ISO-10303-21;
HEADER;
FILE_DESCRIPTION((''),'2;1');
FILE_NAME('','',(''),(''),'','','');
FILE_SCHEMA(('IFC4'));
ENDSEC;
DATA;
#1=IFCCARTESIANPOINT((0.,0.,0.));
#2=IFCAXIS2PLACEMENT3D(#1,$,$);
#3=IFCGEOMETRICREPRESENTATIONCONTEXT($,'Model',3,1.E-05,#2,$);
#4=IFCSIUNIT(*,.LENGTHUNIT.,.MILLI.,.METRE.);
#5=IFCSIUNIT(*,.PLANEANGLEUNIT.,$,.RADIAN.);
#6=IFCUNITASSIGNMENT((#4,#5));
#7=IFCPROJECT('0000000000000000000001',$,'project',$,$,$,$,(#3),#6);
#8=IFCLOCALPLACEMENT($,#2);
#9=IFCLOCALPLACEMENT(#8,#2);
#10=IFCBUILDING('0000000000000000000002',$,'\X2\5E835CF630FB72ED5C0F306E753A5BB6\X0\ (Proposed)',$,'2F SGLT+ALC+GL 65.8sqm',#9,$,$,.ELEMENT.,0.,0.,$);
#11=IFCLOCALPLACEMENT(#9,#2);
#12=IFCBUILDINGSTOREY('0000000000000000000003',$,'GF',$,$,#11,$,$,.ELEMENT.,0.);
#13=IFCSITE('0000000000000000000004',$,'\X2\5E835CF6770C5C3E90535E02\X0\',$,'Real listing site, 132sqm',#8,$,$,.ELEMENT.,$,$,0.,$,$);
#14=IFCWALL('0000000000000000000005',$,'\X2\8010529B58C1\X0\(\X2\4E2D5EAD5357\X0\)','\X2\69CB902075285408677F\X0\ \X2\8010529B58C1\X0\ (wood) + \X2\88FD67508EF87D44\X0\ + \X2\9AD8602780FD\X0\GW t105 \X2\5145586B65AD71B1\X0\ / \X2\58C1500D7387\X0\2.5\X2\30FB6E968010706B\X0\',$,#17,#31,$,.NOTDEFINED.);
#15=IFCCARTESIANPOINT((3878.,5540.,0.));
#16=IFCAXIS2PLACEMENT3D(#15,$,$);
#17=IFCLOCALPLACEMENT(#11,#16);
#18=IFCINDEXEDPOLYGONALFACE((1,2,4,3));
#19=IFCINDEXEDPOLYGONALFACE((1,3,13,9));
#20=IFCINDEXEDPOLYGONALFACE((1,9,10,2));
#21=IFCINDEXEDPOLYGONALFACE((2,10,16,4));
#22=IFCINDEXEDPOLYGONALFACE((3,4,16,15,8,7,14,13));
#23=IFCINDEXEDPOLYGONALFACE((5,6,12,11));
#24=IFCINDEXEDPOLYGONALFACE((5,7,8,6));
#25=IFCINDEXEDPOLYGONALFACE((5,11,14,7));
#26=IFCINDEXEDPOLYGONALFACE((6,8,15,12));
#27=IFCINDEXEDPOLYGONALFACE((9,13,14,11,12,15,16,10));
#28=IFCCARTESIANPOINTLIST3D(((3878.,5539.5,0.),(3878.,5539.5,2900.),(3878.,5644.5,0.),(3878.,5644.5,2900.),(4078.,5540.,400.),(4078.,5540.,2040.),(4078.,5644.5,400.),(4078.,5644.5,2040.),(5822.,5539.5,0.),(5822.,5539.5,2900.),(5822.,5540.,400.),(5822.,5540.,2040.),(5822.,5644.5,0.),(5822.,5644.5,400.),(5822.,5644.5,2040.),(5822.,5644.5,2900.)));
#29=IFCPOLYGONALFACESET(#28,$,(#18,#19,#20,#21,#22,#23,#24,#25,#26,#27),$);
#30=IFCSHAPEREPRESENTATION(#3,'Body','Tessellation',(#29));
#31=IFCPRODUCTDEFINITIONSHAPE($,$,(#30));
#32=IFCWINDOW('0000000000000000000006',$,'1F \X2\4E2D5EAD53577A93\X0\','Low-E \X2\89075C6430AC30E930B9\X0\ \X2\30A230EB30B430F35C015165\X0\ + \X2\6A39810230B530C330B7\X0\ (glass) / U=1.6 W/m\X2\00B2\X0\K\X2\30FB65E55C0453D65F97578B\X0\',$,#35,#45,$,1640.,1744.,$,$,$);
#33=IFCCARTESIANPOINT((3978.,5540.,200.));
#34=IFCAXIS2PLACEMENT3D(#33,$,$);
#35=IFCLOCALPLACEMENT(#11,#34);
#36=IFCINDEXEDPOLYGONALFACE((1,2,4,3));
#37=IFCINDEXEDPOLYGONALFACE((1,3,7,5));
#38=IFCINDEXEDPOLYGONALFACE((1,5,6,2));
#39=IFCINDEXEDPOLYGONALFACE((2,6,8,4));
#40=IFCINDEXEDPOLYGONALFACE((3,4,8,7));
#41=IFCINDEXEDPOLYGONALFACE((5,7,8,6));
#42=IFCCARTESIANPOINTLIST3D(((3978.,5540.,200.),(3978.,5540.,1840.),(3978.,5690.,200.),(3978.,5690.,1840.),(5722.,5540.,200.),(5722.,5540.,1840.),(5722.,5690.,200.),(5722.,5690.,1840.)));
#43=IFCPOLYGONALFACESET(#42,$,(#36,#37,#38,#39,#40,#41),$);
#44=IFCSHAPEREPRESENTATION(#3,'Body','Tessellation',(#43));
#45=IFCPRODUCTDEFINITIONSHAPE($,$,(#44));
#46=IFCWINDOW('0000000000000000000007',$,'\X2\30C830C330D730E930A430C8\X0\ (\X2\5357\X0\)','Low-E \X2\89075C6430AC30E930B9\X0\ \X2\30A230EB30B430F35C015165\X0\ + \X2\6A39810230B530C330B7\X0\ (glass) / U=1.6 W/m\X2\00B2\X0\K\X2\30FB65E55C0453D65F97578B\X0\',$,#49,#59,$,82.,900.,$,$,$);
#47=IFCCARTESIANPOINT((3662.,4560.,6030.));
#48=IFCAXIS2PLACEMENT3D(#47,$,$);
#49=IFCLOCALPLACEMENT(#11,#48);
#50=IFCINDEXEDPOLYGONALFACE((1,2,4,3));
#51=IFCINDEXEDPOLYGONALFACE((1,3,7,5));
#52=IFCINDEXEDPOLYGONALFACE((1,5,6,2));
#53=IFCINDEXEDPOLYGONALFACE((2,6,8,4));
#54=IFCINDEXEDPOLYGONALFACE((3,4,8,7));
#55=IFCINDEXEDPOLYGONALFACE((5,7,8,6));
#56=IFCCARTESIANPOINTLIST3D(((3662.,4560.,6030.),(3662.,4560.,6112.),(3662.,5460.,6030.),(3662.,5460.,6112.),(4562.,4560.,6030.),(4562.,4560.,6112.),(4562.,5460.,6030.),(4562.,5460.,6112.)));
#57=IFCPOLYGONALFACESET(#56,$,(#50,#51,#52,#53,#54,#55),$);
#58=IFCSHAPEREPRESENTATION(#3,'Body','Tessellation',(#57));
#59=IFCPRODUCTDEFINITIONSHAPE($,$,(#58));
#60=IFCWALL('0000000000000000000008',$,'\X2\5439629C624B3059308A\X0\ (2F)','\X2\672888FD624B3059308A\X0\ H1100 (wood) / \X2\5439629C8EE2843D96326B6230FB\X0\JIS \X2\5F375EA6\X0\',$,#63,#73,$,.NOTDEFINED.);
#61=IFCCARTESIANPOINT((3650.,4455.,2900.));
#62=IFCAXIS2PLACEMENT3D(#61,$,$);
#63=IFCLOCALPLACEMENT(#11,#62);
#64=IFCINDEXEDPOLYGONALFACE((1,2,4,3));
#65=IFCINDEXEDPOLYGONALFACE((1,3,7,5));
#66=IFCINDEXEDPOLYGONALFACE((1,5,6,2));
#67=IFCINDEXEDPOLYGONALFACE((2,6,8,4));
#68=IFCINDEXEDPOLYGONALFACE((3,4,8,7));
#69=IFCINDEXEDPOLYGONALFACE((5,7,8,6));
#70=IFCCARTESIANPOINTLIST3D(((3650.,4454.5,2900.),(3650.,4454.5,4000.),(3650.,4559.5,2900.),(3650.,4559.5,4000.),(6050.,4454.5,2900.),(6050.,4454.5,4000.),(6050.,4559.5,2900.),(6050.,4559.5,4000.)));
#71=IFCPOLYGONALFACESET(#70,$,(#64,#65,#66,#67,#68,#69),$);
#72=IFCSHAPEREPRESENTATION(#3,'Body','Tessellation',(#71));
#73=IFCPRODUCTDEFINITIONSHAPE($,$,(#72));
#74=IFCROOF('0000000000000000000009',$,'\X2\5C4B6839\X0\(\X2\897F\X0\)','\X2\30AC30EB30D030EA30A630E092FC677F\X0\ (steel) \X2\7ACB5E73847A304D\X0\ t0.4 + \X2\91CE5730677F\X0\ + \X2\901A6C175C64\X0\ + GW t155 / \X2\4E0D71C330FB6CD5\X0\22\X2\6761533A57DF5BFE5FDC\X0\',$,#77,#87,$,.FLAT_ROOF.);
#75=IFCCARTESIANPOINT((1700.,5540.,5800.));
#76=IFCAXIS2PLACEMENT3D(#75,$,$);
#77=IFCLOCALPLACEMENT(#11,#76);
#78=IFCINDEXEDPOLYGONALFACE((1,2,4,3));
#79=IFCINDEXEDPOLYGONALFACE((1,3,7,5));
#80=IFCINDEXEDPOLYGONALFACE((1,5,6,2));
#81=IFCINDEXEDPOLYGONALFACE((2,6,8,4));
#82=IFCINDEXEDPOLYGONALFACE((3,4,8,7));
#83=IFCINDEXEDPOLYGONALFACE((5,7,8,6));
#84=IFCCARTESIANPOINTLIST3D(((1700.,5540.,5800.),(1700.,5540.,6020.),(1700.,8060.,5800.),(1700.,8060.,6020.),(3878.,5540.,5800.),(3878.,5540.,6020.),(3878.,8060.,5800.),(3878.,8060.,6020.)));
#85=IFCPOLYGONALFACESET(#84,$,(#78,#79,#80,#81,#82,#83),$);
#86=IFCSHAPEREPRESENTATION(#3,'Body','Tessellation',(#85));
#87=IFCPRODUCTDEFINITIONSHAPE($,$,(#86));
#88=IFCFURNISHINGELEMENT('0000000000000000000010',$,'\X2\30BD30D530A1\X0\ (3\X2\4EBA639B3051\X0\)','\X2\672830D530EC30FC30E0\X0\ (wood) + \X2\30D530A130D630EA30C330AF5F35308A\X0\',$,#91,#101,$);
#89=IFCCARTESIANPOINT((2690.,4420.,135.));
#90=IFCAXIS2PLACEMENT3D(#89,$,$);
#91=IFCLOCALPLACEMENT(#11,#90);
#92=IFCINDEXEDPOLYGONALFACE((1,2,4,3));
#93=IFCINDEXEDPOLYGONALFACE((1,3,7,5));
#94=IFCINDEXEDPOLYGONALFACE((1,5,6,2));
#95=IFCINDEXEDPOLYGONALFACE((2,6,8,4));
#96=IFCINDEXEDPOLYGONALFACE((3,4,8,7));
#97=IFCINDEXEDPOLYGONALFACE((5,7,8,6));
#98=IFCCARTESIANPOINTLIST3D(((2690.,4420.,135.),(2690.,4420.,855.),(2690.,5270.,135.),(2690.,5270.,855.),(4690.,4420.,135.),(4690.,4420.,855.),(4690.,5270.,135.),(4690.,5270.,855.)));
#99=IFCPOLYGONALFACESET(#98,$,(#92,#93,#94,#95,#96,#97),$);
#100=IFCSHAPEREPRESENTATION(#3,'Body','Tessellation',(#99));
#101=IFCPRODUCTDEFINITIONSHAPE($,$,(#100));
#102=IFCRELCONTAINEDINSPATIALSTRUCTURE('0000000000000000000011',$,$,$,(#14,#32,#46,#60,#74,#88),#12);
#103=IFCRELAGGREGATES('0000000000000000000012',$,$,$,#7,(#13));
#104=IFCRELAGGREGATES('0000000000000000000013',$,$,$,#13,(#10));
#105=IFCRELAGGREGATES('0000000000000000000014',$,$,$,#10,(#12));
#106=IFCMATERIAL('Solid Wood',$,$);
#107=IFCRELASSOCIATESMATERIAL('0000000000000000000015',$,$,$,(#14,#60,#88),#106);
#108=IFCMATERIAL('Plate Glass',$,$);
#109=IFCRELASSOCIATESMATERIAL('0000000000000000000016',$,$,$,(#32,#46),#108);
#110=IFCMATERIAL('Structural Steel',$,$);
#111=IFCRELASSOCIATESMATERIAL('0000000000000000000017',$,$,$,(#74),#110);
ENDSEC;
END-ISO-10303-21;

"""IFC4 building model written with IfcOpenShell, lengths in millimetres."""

from ifc_helpers import new_model, si_unit, frame, frame_2d, origin, place, context, project, spatial, rectangle, extrude, material, element, fill, save


model = new_model("IFC4")

# Units and contexts
model_context = context("Model", 3, precision=1e-05, world=origin())
ifc_project = project(units=[si_unit("LENGTHUNIT", "METRE", prefix="MILLI"), si_unit("PLANEANGLEUNIT", "RADIAN")], contexts=[model_context])

# Site, building, storey
site_placement = place(None, origin())
site = spatial("IfcSite", under=ifc_project, at=site_placement, Name="広島県尾道市", ObjectType="Real listing site, 132sqm", CompositionType="ELEMENT", RefElevation=0.0)
building_placement = place(site_placement, origin())
building = spatial("IfcBuilding", under=site, at=building_placement, Name="広島・狭小の町家 (Proposed)", ObjectType="2F SGLT+ALC+GL 65.8sqm", CompositionType="ELEMENT", ElevationOfRefHeight=0.0, ElevationOfTerrain=0.0)
storey_placement = place(building_placement, origin())
storey = spatial("IfcBuildingStorey", under=building, at=storey_placement, Name="GF", CompositionType="ELEMENT", Elevation=0.0)

# Shared definitions
ifc_material_1 = material(Name="Solid Wood")

# Wall, opening, window
wall_1_placement = place(storey_placement, frame((3878.0, 5540.0, 0.0)))
wall_1 = element("IfcWall", 1, at=wall_1_placement, inside=storey, material=ifc_material_1, Name="耐力壁(中庭南)", Description="構造用合板 耐力壁 (wood) + 製材軸組 + 高性能GW t105 充填断熱 / 壁倍率2.5・準耐火", PredefinedType="NOTDEFINED", context=model_context, shape_type="SweptSolid", body=[
    extrude(rectangle(XDim=1944.0, YDim=105.0, at=frame_2d((972.0, 52.0))), frame((3878.0, 5540.0, 0.0)), (0.0, 0.0, 1.0), 2900.0),
])
opening_placement = place(storey_placement, frame((3978.0, 5540.0, 200.0)))
opening = element("IfcOpeningElement", 2, at=opening_placement, cuts=wall_1, PredefinedType="NOTDEFINED", context=model_context, shape_type="SweptSolid", body=[
    extrude(rectangle(XDim=1744.0, YDim=150.0, at=frame_2d((872.0, 75.0))), frame((3978.0, 5540.0, 200.0)), (0.0, 0.0, 1.0), 1640.0),
])
ifc_material_2 = material(Name="Plate Glass")
window_1_placement = place(storey_placement, frame((3978.0, 5540.0, 200.0)))
window_1 = element("IfcWindow", 3, at=window_1_placement, inside=storey, material=ifc_material_2, Name="1F 中庭南窓", Description="Low-E 複層ガラス アルゴン封入 + 樹脂サッシ (glass) / U=1.6 W/m²K・日射取得型", OverallHeight=1640.0, OverallWidth=1744.0, context=model_context, shape_type="SweptSolid", body=[
    extrude(rectangle(XDim=1744.0, YDim=150.0, at=frame_2d((872.0, 75.0))), frame((3978.0, 5540.0, 200.0)), (0.0, 0.0, 1.0), 1640.0),
])
fill(opening, window_1)

# Window
window_2_placement = place(storey_placement, frame((3662.0, 4560.0, 6030.0)))
element("IfcWindow", 4, at=window_2_placement, inside=storey, material=ifc_material_2, Name="トップライト (南)", Description="Low-E 複層ガラス アルゴン封入 + 樹脂サッシ (glass) / U=1.6 W/m²K・日射取得型", OverallHeight=82.0, OverallWidth=900.0, context=model_context, shape_type="SweptSolid", body=[
    extrude(rectangle(XDim=900.0, YDim=900.0, at=frame_2d((450.0, 450.0))), frame((3662.0, 4560.0, 6030.0)), (0.0, 0.0, 1.0), 82.0),
])

# Wall
wall_2_placement = place(storey_placement, frame((3650.0, 4455.0, 2900.0)))
element("IfcWall", 5, at=wall_2_placement, inside=storey, material=ifc_material_1, Name="吹抜手すり (2F)", Description="木製手すり H1100 (wood) / 吹抜転落防止・JIS 強度", PredefinedType="NOTDEFINED", context=model_context, shape_type="SweptSolid", body=[
    extrude(rectangle(XDim=2400.0, YDim=105.0, at=frame_2d((1200.0, 52.0))), frame((3650.0, 4455.0, 2900.0)), (0.0, 0.0, 1.0), 1100.0),
])

# Roof
ifc_material_3 = material(Name="Structural Steel")
for number, where, name in (
    (6, (1700.0, 5540.0, 5800.0), "屋根(西)"),
):
    element("IfcRoof", number, at=place(storey_placement, frame(where)), inside=storey, material=ifc_material_3, Name=name, Description="ガルバリウム鋼板 (steel) 立平葺き t0.4 + 野地板 + 通気層 + GW t155 / 不燃・法22条区域対応", PredefinedType="FLAT_ROOF", context=model_context, shape_type="SweptSolid", body=[
        extrude(rectangle(XDim=2178.0, YDim=2520.0, at=frame_2d((1089.0, 1260.0))), frame((1700.0, 5540.0, 5800.0)), (0.0, 0.0, 1.0), 220.0),
    ])

# Furnishing element
furnishing_placement = place(storey_placement, frame((2690.0, 4420.0, 135.0)))
element("IfcFurnishingElement", 7, at=furnishing_placement, inside=storey, material=ifc_material_1, Name="ソファ (3人掛け)", Description="木フレーム (wood) + ファブリック張り", context=model_context, shape_type="SweptSolid", body=[
    extrude(rectangle(XDim=2000.0, YDim=850.0, at=frame_2d((1000.0, 425.0))), frame((2690.0, 4420.0, 135.0)), (0.0, 0.0, 1.0), 720.0),
])

save(model, "model.ifc")
